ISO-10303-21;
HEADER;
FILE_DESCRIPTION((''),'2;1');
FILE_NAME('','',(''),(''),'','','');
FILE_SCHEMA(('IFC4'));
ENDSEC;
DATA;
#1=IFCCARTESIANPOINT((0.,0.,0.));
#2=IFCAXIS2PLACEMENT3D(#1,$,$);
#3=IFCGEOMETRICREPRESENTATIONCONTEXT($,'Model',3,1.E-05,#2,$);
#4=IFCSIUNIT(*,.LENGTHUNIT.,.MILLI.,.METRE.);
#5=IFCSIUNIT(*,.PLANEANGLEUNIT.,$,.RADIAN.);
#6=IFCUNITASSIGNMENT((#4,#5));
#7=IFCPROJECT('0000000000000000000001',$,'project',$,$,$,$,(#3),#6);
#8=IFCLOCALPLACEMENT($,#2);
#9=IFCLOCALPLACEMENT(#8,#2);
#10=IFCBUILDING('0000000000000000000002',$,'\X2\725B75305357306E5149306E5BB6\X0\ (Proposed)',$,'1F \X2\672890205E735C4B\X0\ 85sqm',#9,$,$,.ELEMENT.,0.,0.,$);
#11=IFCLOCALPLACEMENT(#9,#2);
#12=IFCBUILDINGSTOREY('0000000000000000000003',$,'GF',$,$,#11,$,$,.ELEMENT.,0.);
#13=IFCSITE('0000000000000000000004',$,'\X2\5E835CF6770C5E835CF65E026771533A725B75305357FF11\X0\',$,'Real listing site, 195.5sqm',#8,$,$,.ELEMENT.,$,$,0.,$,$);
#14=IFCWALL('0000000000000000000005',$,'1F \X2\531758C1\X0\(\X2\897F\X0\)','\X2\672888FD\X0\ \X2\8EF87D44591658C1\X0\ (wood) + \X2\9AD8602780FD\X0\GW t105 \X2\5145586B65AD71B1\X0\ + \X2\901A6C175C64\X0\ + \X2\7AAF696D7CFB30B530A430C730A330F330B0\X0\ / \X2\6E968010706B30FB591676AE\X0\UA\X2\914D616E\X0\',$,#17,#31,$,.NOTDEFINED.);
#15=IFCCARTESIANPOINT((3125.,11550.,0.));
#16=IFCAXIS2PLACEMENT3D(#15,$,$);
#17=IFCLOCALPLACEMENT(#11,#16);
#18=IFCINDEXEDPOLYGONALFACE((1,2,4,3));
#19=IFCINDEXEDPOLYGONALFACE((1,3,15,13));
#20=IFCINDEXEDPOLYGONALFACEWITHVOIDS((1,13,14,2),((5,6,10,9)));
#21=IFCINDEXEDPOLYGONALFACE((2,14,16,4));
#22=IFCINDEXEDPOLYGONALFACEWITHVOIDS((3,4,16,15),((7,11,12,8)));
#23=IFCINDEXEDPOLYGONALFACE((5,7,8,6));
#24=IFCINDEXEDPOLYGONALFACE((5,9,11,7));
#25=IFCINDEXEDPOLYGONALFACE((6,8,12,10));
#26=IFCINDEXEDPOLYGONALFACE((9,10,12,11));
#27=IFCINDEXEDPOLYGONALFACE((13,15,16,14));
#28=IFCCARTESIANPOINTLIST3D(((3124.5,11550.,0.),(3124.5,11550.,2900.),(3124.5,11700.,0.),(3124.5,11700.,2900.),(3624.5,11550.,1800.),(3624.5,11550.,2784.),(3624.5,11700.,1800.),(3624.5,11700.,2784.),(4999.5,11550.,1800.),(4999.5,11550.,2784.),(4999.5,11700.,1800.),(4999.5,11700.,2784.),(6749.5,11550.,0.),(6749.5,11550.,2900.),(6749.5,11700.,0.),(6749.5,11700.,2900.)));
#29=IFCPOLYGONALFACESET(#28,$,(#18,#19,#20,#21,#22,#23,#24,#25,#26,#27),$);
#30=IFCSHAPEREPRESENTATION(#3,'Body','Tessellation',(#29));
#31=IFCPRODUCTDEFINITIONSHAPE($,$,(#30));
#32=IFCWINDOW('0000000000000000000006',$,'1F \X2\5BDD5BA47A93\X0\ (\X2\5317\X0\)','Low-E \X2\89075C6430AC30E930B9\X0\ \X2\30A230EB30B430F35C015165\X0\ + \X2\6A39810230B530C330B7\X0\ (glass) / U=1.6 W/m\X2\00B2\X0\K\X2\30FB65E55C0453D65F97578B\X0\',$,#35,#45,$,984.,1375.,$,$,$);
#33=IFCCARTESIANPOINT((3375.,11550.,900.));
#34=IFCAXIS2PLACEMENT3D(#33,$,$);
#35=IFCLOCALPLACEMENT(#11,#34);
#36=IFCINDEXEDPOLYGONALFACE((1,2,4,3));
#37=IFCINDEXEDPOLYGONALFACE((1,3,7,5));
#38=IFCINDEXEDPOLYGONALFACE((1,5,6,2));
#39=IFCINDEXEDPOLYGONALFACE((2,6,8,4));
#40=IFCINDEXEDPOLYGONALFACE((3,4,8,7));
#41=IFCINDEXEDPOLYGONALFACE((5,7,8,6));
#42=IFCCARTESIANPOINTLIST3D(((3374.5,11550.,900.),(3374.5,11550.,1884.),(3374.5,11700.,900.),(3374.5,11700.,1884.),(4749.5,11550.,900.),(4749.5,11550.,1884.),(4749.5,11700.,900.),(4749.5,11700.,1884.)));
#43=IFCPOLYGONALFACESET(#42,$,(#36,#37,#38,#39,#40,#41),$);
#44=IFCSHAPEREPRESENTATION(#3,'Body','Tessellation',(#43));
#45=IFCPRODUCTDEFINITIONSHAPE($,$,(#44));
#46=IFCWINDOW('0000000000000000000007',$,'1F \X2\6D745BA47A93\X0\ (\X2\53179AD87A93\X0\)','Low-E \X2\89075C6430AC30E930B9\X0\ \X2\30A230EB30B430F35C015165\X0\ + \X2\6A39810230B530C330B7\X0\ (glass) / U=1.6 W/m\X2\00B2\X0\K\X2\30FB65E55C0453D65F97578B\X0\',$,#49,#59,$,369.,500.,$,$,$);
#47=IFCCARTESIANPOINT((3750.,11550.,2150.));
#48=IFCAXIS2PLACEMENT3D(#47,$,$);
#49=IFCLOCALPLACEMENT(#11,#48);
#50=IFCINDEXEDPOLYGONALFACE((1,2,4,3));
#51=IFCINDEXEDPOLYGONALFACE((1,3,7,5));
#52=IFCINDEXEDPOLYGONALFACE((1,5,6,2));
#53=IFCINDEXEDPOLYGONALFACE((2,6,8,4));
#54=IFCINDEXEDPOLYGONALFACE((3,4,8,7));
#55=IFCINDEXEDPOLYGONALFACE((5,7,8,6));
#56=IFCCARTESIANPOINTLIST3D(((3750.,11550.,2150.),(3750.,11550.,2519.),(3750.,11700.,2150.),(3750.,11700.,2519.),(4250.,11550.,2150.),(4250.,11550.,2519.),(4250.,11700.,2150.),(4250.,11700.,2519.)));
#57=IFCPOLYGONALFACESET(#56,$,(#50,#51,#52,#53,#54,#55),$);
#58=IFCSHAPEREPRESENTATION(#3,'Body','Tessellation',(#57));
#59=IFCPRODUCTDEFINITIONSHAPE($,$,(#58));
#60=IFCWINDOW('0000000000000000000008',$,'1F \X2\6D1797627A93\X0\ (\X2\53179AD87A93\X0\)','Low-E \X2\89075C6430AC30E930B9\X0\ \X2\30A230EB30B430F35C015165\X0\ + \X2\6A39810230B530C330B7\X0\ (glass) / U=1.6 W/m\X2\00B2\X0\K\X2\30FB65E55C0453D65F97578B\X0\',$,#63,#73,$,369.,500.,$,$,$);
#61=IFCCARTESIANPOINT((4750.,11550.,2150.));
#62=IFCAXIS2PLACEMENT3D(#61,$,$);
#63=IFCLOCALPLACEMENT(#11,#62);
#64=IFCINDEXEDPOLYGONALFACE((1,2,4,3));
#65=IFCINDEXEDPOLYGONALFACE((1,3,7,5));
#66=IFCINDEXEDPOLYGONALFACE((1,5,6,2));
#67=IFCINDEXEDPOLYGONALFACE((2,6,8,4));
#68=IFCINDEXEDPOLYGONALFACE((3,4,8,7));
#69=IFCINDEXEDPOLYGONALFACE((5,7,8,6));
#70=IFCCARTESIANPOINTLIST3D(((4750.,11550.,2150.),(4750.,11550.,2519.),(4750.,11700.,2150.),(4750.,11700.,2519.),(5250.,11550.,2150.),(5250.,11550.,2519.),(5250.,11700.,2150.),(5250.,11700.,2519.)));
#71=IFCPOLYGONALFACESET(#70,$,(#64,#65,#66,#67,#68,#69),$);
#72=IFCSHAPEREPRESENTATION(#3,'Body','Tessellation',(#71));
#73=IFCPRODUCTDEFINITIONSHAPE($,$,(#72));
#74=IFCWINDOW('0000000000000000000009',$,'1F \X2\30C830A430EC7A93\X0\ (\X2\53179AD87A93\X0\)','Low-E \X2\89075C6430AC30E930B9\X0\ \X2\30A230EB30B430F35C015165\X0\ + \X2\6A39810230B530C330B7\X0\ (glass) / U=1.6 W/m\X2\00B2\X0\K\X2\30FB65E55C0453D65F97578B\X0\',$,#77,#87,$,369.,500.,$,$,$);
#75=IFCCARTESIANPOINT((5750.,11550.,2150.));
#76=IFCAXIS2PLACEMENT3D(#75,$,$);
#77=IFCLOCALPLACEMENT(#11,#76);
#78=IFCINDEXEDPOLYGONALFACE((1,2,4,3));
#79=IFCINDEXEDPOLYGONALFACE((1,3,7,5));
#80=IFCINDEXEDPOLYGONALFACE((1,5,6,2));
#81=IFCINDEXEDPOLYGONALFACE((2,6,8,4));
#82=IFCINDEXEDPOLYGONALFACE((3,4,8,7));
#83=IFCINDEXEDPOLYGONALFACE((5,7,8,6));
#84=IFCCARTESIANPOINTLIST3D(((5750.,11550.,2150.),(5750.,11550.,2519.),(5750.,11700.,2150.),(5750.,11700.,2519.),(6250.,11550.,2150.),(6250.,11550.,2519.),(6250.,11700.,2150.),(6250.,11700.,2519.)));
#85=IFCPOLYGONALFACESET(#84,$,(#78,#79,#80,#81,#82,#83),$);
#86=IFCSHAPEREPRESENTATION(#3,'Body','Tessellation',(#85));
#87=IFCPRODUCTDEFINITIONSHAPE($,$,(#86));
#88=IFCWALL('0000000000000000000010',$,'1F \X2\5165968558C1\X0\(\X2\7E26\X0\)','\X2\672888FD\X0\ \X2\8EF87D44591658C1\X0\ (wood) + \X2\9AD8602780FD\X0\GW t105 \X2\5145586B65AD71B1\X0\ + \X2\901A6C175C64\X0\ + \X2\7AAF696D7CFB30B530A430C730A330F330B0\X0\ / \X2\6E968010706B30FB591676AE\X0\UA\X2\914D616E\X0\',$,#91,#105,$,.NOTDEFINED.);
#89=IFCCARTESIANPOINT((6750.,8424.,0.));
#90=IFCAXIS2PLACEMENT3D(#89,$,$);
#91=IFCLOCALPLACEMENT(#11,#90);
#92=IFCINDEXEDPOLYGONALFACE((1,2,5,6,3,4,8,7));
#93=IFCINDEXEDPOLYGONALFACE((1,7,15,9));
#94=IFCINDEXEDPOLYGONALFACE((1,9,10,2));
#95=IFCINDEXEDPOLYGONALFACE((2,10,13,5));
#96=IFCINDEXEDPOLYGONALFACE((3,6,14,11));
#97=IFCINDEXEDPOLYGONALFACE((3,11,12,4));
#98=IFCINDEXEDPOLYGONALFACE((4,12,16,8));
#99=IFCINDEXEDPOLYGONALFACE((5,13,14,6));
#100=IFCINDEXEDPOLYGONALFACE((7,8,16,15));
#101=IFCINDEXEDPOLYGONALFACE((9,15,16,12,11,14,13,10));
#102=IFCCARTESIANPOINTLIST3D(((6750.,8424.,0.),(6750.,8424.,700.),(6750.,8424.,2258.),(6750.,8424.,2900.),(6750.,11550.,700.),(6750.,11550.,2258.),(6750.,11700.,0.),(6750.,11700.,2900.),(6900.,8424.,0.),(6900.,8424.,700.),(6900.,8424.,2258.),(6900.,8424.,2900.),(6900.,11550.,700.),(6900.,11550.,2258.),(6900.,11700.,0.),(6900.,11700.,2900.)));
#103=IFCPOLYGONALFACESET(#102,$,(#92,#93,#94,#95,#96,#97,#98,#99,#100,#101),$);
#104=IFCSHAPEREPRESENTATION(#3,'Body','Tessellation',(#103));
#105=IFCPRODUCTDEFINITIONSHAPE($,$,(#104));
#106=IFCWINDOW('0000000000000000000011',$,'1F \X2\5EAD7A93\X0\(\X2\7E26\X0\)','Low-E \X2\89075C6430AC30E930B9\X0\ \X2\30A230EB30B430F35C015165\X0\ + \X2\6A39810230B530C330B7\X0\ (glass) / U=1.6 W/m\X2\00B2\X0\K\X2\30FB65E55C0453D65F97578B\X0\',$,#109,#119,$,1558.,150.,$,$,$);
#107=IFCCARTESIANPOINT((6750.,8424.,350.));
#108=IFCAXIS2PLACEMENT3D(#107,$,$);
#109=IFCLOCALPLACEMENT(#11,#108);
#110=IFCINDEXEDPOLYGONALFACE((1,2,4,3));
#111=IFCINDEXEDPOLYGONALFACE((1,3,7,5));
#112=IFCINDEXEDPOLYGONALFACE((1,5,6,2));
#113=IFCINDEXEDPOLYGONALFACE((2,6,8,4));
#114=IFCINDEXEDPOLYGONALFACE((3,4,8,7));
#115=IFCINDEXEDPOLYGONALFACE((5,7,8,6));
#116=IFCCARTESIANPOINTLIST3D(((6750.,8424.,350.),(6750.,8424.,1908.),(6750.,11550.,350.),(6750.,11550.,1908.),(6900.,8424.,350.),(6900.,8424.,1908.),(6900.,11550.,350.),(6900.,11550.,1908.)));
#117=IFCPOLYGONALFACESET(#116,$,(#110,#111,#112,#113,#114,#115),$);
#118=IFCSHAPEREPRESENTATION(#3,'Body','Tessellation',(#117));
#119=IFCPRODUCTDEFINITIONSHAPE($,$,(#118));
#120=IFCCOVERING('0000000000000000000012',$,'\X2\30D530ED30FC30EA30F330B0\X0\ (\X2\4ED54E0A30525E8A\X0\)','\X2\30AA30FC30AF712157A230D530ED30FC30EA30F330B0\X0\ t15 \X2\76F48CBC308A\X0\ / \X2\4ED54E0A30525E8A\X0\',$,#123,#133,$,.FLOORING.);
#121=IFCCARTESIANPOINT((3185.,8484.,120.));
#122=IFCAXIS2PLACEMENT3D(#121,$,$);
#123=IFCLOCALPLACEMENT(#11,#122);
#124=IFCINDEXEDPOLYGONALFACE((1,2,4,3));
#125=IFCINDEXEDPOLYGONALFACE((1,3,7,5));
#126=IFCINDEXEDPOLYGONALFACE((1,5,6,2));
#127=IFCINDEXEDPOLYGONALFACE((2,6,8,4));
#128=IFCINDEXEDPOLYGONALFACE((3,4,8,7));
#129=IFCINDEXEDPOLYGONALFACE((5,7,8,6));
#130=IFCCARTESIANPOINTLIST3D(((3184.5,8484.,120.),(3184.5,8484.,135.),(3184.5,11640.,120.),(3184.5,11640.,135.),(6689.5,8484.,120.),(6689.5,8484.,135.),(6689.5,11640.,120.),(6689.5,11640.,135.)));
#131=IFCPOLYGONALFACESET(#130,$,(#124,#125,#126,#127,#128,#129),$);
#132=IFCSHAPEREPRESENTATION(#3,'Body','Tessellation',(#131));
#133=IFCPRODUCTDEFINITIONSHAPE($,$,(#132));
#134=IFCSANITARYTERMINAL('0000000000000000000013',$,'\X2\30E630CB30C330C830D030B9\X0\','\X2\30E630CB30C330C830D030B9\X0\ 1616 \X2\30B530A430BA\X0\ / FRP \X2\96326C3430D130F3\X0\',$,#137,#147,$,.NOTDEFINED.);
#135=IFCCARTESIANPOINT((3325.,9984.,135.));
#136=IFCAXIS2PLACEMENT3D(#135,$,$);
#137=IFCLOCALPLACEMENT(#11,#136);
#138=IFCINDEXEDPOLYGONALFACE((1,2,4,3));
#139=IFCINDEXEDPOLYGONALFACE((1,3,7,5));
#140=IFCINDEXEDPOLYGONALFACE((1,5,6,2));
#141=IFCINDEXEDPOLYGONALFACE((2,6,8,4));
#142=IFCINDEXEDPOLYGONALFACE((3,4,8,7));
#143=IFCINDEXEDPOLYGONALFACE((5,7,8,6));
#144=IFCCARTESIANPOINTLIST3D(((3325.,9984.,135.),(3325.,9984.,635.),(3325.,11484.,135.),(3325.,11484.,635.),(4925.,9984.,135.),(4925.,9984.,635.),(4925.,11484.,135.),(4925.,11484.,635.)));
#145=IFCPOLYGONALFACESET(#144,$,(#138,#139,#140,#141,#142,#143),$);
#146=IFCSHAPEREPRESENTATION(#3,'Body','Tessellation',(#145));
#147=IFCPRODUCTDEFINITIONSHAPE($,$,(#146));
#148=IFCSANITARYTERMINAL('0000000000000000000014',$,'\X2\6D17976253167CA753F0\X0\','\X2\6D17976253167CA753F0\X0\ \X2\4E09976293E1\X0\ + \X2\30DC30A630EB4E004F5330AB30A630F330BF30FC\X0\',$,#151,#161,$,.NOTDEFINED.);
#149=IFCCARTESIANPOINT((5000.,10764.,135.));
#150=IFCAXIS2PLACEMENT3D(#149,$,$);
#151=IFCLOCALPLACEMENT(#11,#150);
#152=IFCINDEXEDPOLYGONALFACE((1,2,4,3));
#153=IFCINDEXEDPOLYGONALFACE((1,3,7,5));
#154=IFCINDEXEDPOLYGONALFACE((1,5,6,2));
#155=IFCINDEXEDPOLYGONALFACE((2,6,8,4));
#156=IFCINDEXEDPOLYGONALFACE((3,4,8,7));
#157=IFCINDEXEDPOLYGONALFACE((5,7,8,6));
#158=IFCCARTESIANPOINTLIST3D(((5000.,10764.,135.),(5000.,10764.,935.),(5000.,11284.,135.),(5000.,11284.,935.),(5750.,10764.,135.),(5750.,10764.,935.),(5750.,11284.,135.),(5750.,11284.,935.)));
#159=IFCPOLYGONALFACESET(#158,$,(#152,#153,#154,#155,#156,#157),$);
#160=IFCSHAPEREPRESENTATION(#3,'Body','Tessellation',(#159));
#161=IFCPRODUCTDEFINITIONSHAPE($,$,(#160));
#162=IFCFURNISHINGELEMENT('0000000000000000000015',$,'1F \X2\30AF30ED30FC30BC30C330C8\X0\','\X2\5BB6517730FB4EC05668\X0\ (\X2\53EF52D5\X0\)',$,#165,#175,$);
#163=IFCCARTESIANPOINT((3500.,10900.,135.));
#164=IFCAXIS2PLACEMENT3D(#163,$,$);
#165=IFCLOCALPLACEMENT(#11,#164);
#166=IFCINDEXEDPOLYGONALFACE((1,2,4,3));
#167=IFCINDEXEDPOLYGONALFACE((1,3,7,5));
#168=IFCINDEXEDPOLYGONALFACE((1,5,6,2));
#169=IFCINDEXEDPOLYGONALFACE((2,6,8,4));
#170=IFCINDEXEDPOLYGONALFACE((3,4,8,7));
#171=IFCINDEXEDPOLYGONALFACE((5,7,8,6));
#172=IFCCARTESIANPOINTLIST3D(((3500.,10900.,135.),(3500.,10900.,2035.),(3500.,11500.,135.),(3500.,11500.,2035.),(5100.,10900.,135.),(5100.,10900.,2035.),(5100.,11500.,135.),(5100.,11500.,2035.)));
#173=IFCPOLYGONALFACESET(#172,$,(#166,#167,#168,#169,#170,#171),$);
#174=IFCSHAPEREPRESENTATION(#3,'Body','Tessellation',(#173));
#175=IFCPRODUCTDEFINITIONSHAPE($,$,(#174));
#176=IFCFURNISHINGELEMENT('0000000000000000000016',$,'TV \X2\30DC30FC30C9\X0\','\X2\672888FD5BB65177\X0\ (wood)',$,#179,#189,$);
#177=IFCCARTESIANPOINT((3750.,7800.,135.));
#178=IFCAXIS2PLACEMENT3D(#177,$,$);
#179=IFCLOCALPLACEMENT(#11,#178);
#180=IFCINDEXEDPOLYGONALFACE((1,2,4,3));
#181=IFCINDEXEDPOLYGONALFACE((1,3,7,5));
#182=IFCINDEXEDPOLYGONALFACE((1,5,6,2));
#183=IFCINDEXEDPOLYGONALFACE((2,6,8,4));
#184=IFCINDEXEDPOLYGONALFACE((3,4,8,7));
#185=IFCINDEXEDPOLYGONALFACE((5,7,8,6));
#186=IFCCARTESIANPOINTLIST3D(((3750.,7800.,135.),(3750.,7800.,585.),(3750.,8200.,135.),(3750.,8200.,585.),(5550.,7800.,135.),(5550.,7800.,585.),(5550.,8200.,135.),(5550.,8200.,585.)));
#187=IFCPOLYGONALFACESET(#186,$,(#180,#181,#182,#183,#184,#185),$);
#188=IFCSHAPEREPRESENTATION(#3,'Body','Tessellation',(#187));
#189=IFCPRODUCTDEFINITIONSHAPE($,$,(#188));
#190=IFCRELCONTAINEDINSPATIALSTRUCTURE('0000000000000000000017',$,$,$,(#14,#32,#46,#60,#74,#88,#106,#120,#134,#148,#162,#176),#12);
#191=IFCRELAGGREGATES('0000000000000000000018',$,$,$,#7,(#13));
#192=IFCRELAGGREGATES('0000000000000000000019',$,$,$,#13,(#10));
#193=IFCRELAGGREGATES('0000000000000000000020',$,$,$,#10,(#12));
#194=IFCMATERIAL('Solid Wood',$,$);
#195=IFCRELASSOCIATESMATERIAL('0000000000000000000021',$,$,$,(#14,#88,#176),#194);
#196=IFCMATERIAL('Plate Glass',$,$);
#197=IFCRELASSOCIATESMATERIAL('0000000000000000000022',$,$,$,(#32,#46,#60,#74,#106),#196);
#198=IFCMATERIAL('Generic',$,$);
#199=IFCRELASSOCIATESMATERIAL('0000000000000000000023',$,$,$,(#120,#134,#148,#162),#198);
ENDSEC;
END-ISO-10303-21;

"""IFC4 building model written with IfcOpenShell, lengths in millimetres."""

from ifc_helpers import new_model, si_unit, frame, frame_2d, origin, place, context, project, spatial, rectangle, extrude, material, element, fill, save


model = new_model("IFC4")

# Units and contexts
model_context = context("Model", 3, precision=1e-05, world=origin())
ifc_project = project(units=[si_unit("LENGTHUNIT", "METRE", prefix="MILLI"), si_unit("PLANEANGLEUNIT", "RADIAN")], contexts=[model_context])

# Site, building, storey
site_placement = place(None, origin())
site = spatial("IfcSite", under=ifc_project, at=site_placement, Name="広島県広島市東区牛田南１", ObjectType="Real listing site, 195.5sqm", CompositionType="ELEMENT", RefElevation=0.0)
building_placement = place(site_placement, origin())
building = spatial("IfcBuilding", under=site, at=building_placement, Name="牛田南の光の家 (Proposed)", ObjectType="1F 木造平屋 85sqm", CompositionType="ELEMENT", ElevationOfRefHeight=0.0, ElevationOfTerrain=0.0)
storey_placement = place(building_placement, origin())
storey = spatial("IfcBuildingStorey", under=building, at=storey_placement, Name="GF", CompositionType="ELEMENT", Elevation=0.0)

# Shared definitions
ifc_material_1 = material(Name="Solid Wood")

# Wall, openings, windows
wall_1_placement = place(storey_placement, frame((3125.0, 11550.0, 0.0)))
wall_1 = element("IfcWall", 1, at=wall_1_placement, inside=storey, material=ifc_material_1, Name="1F 北壁(西)", Description="木製 軸組外壁 (wood) + 高性能GW t105 充填断熱 + 通気層 + 窯業系サイディング / 準耐火・外皮UA配慮", PredefinedType="NOTDEFINED", context=model_context, shape_type="SweptSolid", body=[
    extrude(rectangle(XDim=3625.0, YDim=150.0, at=frame_2d((1812.0, 75.0))), frame((3125.0, 11550.0, 0.0)), (0.0, 0.0, 1.0), 2900.0),
])
opening_1_placement = place(storey_placement, frame((3375.0, 11550.0, 900.0)))
opening_1 = element("IfcOpeningElement", 2, at=opening_1_placement, cuts=wall_1, PredefinedType="NOTDEFINED", context=model_context, shape_type="SweptSolid", body=[
    extrude(rectangle(XDim=1375.0, YDim=150.0, at=frame_2d((687.0, 75.0))), frame((3375.0, 11550.0, 900.0)), (0.0, 0.0, 1.0), 984.0),
])
opening_2_placement = place(storey_placement, frame((3750.0, 11550.0, 2150.0)))
opening_2 = element("IfcOpeningElement", 3, at=opening_2_placement, cuts=wall_1, PredefinedType="NOTDEFINED", context=model_context, shape_type="SweptSolid", body=[
    extrude(rectangle(XDim=500.0, YDim=150.0, at=frame_2d((250.0, 75.0))), frame((3750.0, 11550.0, 2150.0)), (0.0, 0.0, 1.0), 369.0),
])
opening_3_placement = place(storey_placement, frame((4750.0, 11550.0, 2150.0)))
opening_3 = element("IfcOpeningElement", 4, at=opening_3_placement, cuts=wall_1, PredefinedType="NOTDEFINED", context=model_context, shape_type="SweptSolid", body=[
    extrude(rectangle(XDim=500.0, YDim=150.0, at=frame_2d((250.0, 75.0))), frame((4750.0, 11550.0, 2150.0)), (0.0, 0.0, 1.0), 369.0),
])
opening_4_placement = place(storey_placement, frame((5750.0, 11550.0, 2150.0)))
opening_4 = element("IfcOpeningElement", 5, at=opening_4_placement, cuts=wall_1, PredefinedType="NOTDEFINED", context=model_context, shape_type="SweptSolid", body=[
    extrude(rectangle(XDim=500.0, YDim=150.0, at=frame_2d((250.0, 75.0))), frame((5750.0, 11550.0, 2150.0)), (0.0, 0.0, 1.0), 369.0),
])
ifc_material_2 = material(Name="Plate Glass")
window_1_placement = place(storey_placement, frame((3375.0, 11550.0, 900.0)))
window_1 = element("IfcWindow", 6, at=window_1_placement, inside=storey, material=ifc_material_2, Name="1F 寝室窓 (北)", Description="Low-E 複層ガラス アルゴン封入 + 樹脂サッシ (glass) / U=1.6 W/m²K・日射取得型", OverallHeight=984.0, OverallWidth=1375.0, context=model_context, shape_type="SweptSolid", body=[
    extrude(rectangle(XDim=1375.0, YDim=150.0, at=frame_2d((687.0, 75.0))), frame((3375.0, 11550.0, 900.0)), (0.0, 0.0, 1.0), 984.0),
])
fill(opening_1, window_1)
window_2_placement = place(storey_placement, frame((3750.0, 11550.0, 2150.0)))
window_2 = element("IfcWindow", 7, at=window_2_placement, inside=storey, material=ifc_material_2, Name="1F 浴室窓 (北高窓)", Description="Low-E 複層ガラス アルゴン封入 + 樹脂サッシ (glass) / U=1.6 W/m²K・日射取得型", OverallHeight=369.0, OverallWidth=500.0, context=model_context, shape_type="SweptSolid", body=[
    extrude(rectangle(XDim=500.0, YDim=150.0, at=frame_2d((250.0, 75.0))), frame((3750.0, 11550.0, 2150.0)), (0.0, 0.0, 1.0), 369.0),
])
fill(opening_2, window_2)
window_3_placement = place(storey_placement, frame((4750.0, 11550.0, 2150.0)))
window_3 = element("IfcWindow", 8, at=window_3_placement, inside=storey, material=ifc_material_2, Name="1F 洗面窓 (北高窓)", Description="Low-E 複層ガラス アルゴン封入 + 樹脂サッシ (glass) / U=1.6 W/m²K・日射取得型", OverallHeight=369.0, OverallWidth=500.0, context=model_context, shape_type="SweptSolid", body=[
    extrude(rectangle(XDim=500.0, YDim=150.0, at=frame_2d((250.0, 75.0))), frame((4750.0, 11550.0, 2150.0)), (0.0, 0.0, 1.0), 369.0),
])
fill(opening_3, window_3)
window_4_placement = place(storey_placement, frame((5750.0, 11550.0, 2150.0)))
window_4 = element("IfcWindow", 9, at=window_4_placement, inside=storey, material=ifc_material_2, Name="1F トイレ窓 (北高窓)", Description="Low-E 複層ガラス アルゴン封入 + 樹脂サッシ (glass) / U=1.6 W/m²K・日射取得型", OverallHeight=369.0, OverallWidth=500.0, context=model_context, shape_type="SweptSolid", body=[
    extrude(rectangle(XDim=500.0, YDim=150.0, at=frame_2d((250.0, 75.0))), frame((5750.0, 11550.0, 2150.0)), (0.0, 0.0, 1.0), 369.0),
])
fill(opening_4, window_4)

# Wall, opening, window
wall_2_placement = place(storey_placement, frame((6750.0, 8424.0, 0.0)))
wall_2 = element("IfcWall", 10, at=wall_2_placement, inside=storey, material=ifc_material_1, Name="1F 入隅壁(縦)", Description="木製 軸組外壁 (wood) + 高性能GW t105 充填断熱 + 通気層 + 窯業系サイディング / 準耐火・外皮UA配慮", PredefinedType="NOTDEFINED", context=model_context, shape_type="SweptSolid", body=[
    extrude(rectangle(XDim=150.0, YDim=3276.0, at=frame_2d((75.0, 1638.0))), frame((6750.0, 8424.0, 0.0)), (0.0, 0.0, 1.0), 2900.0),
])
opening_5_placement = place(storey_placement, frame((6750.0, 8424.0, 350.0)))
opening_5 = element("IfcOpeningElement", 11, at=opening_5_placement, cuts=wall_2, PredefinedType="NOTDEFINED", context=model_context, shape_type="SweptSolid", body=[
    extrude(rectangle(XDim=150.0, YDim=3126.0, at=frame_2d((75.0, 1563.0))), frame((6750.0, 8424.0, 350.0)), (0.0, 0.0, 1.0), 1558.0),
])
window_5_placement = place(storey_placement, frame((6750.0, 8424.0, 350.0)))
window_5 = element("IfcWindow", 12, at=window_5_placement, inside=storey, material=ifc_material_2, Name="1F 庭窓(縦)", Description="Low-E 複層ガラス アルゴン封入 + 樹脂サッシ (glass) / U=1.6 W/m²K・日射取得型", OverallHeight=1558.0, OverallWidth=150.0, context=model_context, shape_type="SweptSolid", body=[
    extrude(rectangle(XDim=150.0, YDim=3126.0, at=frame_2d((75.0, 1563.0))), frame((6750.0, 8424.0, 350.0)), (0.0, 0.0, 1.0), 1558.0),
])
fill(opening_5, window_5)

# Covering
ifc_material_3 = material(Name="Generic")
covering_placement = place(storey_placement, frame((3185.0, 8484.0, 120.0)))
element("IfcCovering", 13, at=covering_placement, inside=storey, material=ifc_material_3, Name="フローリング (仕上げ床)", Description="オーク無垢フローリング t15 直貼り / 仕上げ床", PredefinedType="FLOORING", context=model_context, shape_type="SweptSolid", body=[
    extrude(rectangle(XDim=3505.0, YDim=3156.0, at=frame_2d((1752.0, 1578.0))), frame((3185.0, 8484.0, 120.0)), (0.0, 0.0, 1.0), 15.0),
])

# Sanitary terminals
sanitary_terminal_1_placement = place(storey_placement, frame((3325.0, 9984.0, 135.0)))
element("IfcSanitaryTerminal", 14, at=sanitary_terminal_1_placement, inside=storey, material=ifc_material_3, Name="ユニットバス", Description="ユニットバス 1616 サイズ / FRP 防水パン", PredefinedType="NOTDEFINED", context=model_context, shape_type="SweptSolid", body=[
    extrude(rectangle(XDim=1600.0, YDim=1500.0, at=frame_2d((800.0, 750.0))), frame((3325.0, 9984.0, 135.0)), (0.0, 0.0, 1.0), 500.0),
])
sanitary_terminal_2_placement = place(storey_placement, frame((5000.0, 10764.0, 135.0)))
element("IfcSanitaryTerminal", 15, at=sanitary_terminal_2_placement, inside=storey, material=ifc_material_3, Name="洗面化粧台", Description="洗面化粧台 三面鏡 + ボウル一体カウンター", PredefinedType="NOTDEFINED", context=model_context, shape_type="SweptSolid", body=[
    extrude(rectangle(XDim=750.0, YDim=520.0, at=frame_2d((375.0, 260.0))), frame((5000.0, 10764.0, 135.0)), (0.0, 0.0, 1.0), 800.0),
])

# Furnishing elements
furnishing_1_placement = place(storey_placement, frame((3500.0, 10900.0, 135.0)))
element("IfcFurnishingElement", 16, at=furnishing_1_placement, inside=storey, material=ifc_material_3, Name="1F クローゼット", Description="家具・什器 (可動)", context=model_context, shape_type="SweptSolid", body=[
    extrude(rectangle(XDim=1600.0, YDim=600.0, at=frame_2d((800.0, 300.0))), frame((3500.0, 10900.0, 135.0)), (0.0, 0.0, 1.0), 1900.0),
])
furnishing_2_placement = place(storey_placement, frame((3750.0, 7800.0, 135.0)))
element("IfcFurnishingElement", 17, at=furnishing_2_placement, inside=storey, material=ifc_material_1, Name="TV ボード", Description="木製家具 (wood)", context=model_context, shape_type="SweptSolid", body=[
    extrude(rectangle(XDim=1800.0, YDim=400.0, at=frame_2d((900.0, 200.0))), frame((3750.0, 7800.0, 135.0)), (0.0, 0.0, 1.0), 450.0),
])

save(model, "model.ifc")
